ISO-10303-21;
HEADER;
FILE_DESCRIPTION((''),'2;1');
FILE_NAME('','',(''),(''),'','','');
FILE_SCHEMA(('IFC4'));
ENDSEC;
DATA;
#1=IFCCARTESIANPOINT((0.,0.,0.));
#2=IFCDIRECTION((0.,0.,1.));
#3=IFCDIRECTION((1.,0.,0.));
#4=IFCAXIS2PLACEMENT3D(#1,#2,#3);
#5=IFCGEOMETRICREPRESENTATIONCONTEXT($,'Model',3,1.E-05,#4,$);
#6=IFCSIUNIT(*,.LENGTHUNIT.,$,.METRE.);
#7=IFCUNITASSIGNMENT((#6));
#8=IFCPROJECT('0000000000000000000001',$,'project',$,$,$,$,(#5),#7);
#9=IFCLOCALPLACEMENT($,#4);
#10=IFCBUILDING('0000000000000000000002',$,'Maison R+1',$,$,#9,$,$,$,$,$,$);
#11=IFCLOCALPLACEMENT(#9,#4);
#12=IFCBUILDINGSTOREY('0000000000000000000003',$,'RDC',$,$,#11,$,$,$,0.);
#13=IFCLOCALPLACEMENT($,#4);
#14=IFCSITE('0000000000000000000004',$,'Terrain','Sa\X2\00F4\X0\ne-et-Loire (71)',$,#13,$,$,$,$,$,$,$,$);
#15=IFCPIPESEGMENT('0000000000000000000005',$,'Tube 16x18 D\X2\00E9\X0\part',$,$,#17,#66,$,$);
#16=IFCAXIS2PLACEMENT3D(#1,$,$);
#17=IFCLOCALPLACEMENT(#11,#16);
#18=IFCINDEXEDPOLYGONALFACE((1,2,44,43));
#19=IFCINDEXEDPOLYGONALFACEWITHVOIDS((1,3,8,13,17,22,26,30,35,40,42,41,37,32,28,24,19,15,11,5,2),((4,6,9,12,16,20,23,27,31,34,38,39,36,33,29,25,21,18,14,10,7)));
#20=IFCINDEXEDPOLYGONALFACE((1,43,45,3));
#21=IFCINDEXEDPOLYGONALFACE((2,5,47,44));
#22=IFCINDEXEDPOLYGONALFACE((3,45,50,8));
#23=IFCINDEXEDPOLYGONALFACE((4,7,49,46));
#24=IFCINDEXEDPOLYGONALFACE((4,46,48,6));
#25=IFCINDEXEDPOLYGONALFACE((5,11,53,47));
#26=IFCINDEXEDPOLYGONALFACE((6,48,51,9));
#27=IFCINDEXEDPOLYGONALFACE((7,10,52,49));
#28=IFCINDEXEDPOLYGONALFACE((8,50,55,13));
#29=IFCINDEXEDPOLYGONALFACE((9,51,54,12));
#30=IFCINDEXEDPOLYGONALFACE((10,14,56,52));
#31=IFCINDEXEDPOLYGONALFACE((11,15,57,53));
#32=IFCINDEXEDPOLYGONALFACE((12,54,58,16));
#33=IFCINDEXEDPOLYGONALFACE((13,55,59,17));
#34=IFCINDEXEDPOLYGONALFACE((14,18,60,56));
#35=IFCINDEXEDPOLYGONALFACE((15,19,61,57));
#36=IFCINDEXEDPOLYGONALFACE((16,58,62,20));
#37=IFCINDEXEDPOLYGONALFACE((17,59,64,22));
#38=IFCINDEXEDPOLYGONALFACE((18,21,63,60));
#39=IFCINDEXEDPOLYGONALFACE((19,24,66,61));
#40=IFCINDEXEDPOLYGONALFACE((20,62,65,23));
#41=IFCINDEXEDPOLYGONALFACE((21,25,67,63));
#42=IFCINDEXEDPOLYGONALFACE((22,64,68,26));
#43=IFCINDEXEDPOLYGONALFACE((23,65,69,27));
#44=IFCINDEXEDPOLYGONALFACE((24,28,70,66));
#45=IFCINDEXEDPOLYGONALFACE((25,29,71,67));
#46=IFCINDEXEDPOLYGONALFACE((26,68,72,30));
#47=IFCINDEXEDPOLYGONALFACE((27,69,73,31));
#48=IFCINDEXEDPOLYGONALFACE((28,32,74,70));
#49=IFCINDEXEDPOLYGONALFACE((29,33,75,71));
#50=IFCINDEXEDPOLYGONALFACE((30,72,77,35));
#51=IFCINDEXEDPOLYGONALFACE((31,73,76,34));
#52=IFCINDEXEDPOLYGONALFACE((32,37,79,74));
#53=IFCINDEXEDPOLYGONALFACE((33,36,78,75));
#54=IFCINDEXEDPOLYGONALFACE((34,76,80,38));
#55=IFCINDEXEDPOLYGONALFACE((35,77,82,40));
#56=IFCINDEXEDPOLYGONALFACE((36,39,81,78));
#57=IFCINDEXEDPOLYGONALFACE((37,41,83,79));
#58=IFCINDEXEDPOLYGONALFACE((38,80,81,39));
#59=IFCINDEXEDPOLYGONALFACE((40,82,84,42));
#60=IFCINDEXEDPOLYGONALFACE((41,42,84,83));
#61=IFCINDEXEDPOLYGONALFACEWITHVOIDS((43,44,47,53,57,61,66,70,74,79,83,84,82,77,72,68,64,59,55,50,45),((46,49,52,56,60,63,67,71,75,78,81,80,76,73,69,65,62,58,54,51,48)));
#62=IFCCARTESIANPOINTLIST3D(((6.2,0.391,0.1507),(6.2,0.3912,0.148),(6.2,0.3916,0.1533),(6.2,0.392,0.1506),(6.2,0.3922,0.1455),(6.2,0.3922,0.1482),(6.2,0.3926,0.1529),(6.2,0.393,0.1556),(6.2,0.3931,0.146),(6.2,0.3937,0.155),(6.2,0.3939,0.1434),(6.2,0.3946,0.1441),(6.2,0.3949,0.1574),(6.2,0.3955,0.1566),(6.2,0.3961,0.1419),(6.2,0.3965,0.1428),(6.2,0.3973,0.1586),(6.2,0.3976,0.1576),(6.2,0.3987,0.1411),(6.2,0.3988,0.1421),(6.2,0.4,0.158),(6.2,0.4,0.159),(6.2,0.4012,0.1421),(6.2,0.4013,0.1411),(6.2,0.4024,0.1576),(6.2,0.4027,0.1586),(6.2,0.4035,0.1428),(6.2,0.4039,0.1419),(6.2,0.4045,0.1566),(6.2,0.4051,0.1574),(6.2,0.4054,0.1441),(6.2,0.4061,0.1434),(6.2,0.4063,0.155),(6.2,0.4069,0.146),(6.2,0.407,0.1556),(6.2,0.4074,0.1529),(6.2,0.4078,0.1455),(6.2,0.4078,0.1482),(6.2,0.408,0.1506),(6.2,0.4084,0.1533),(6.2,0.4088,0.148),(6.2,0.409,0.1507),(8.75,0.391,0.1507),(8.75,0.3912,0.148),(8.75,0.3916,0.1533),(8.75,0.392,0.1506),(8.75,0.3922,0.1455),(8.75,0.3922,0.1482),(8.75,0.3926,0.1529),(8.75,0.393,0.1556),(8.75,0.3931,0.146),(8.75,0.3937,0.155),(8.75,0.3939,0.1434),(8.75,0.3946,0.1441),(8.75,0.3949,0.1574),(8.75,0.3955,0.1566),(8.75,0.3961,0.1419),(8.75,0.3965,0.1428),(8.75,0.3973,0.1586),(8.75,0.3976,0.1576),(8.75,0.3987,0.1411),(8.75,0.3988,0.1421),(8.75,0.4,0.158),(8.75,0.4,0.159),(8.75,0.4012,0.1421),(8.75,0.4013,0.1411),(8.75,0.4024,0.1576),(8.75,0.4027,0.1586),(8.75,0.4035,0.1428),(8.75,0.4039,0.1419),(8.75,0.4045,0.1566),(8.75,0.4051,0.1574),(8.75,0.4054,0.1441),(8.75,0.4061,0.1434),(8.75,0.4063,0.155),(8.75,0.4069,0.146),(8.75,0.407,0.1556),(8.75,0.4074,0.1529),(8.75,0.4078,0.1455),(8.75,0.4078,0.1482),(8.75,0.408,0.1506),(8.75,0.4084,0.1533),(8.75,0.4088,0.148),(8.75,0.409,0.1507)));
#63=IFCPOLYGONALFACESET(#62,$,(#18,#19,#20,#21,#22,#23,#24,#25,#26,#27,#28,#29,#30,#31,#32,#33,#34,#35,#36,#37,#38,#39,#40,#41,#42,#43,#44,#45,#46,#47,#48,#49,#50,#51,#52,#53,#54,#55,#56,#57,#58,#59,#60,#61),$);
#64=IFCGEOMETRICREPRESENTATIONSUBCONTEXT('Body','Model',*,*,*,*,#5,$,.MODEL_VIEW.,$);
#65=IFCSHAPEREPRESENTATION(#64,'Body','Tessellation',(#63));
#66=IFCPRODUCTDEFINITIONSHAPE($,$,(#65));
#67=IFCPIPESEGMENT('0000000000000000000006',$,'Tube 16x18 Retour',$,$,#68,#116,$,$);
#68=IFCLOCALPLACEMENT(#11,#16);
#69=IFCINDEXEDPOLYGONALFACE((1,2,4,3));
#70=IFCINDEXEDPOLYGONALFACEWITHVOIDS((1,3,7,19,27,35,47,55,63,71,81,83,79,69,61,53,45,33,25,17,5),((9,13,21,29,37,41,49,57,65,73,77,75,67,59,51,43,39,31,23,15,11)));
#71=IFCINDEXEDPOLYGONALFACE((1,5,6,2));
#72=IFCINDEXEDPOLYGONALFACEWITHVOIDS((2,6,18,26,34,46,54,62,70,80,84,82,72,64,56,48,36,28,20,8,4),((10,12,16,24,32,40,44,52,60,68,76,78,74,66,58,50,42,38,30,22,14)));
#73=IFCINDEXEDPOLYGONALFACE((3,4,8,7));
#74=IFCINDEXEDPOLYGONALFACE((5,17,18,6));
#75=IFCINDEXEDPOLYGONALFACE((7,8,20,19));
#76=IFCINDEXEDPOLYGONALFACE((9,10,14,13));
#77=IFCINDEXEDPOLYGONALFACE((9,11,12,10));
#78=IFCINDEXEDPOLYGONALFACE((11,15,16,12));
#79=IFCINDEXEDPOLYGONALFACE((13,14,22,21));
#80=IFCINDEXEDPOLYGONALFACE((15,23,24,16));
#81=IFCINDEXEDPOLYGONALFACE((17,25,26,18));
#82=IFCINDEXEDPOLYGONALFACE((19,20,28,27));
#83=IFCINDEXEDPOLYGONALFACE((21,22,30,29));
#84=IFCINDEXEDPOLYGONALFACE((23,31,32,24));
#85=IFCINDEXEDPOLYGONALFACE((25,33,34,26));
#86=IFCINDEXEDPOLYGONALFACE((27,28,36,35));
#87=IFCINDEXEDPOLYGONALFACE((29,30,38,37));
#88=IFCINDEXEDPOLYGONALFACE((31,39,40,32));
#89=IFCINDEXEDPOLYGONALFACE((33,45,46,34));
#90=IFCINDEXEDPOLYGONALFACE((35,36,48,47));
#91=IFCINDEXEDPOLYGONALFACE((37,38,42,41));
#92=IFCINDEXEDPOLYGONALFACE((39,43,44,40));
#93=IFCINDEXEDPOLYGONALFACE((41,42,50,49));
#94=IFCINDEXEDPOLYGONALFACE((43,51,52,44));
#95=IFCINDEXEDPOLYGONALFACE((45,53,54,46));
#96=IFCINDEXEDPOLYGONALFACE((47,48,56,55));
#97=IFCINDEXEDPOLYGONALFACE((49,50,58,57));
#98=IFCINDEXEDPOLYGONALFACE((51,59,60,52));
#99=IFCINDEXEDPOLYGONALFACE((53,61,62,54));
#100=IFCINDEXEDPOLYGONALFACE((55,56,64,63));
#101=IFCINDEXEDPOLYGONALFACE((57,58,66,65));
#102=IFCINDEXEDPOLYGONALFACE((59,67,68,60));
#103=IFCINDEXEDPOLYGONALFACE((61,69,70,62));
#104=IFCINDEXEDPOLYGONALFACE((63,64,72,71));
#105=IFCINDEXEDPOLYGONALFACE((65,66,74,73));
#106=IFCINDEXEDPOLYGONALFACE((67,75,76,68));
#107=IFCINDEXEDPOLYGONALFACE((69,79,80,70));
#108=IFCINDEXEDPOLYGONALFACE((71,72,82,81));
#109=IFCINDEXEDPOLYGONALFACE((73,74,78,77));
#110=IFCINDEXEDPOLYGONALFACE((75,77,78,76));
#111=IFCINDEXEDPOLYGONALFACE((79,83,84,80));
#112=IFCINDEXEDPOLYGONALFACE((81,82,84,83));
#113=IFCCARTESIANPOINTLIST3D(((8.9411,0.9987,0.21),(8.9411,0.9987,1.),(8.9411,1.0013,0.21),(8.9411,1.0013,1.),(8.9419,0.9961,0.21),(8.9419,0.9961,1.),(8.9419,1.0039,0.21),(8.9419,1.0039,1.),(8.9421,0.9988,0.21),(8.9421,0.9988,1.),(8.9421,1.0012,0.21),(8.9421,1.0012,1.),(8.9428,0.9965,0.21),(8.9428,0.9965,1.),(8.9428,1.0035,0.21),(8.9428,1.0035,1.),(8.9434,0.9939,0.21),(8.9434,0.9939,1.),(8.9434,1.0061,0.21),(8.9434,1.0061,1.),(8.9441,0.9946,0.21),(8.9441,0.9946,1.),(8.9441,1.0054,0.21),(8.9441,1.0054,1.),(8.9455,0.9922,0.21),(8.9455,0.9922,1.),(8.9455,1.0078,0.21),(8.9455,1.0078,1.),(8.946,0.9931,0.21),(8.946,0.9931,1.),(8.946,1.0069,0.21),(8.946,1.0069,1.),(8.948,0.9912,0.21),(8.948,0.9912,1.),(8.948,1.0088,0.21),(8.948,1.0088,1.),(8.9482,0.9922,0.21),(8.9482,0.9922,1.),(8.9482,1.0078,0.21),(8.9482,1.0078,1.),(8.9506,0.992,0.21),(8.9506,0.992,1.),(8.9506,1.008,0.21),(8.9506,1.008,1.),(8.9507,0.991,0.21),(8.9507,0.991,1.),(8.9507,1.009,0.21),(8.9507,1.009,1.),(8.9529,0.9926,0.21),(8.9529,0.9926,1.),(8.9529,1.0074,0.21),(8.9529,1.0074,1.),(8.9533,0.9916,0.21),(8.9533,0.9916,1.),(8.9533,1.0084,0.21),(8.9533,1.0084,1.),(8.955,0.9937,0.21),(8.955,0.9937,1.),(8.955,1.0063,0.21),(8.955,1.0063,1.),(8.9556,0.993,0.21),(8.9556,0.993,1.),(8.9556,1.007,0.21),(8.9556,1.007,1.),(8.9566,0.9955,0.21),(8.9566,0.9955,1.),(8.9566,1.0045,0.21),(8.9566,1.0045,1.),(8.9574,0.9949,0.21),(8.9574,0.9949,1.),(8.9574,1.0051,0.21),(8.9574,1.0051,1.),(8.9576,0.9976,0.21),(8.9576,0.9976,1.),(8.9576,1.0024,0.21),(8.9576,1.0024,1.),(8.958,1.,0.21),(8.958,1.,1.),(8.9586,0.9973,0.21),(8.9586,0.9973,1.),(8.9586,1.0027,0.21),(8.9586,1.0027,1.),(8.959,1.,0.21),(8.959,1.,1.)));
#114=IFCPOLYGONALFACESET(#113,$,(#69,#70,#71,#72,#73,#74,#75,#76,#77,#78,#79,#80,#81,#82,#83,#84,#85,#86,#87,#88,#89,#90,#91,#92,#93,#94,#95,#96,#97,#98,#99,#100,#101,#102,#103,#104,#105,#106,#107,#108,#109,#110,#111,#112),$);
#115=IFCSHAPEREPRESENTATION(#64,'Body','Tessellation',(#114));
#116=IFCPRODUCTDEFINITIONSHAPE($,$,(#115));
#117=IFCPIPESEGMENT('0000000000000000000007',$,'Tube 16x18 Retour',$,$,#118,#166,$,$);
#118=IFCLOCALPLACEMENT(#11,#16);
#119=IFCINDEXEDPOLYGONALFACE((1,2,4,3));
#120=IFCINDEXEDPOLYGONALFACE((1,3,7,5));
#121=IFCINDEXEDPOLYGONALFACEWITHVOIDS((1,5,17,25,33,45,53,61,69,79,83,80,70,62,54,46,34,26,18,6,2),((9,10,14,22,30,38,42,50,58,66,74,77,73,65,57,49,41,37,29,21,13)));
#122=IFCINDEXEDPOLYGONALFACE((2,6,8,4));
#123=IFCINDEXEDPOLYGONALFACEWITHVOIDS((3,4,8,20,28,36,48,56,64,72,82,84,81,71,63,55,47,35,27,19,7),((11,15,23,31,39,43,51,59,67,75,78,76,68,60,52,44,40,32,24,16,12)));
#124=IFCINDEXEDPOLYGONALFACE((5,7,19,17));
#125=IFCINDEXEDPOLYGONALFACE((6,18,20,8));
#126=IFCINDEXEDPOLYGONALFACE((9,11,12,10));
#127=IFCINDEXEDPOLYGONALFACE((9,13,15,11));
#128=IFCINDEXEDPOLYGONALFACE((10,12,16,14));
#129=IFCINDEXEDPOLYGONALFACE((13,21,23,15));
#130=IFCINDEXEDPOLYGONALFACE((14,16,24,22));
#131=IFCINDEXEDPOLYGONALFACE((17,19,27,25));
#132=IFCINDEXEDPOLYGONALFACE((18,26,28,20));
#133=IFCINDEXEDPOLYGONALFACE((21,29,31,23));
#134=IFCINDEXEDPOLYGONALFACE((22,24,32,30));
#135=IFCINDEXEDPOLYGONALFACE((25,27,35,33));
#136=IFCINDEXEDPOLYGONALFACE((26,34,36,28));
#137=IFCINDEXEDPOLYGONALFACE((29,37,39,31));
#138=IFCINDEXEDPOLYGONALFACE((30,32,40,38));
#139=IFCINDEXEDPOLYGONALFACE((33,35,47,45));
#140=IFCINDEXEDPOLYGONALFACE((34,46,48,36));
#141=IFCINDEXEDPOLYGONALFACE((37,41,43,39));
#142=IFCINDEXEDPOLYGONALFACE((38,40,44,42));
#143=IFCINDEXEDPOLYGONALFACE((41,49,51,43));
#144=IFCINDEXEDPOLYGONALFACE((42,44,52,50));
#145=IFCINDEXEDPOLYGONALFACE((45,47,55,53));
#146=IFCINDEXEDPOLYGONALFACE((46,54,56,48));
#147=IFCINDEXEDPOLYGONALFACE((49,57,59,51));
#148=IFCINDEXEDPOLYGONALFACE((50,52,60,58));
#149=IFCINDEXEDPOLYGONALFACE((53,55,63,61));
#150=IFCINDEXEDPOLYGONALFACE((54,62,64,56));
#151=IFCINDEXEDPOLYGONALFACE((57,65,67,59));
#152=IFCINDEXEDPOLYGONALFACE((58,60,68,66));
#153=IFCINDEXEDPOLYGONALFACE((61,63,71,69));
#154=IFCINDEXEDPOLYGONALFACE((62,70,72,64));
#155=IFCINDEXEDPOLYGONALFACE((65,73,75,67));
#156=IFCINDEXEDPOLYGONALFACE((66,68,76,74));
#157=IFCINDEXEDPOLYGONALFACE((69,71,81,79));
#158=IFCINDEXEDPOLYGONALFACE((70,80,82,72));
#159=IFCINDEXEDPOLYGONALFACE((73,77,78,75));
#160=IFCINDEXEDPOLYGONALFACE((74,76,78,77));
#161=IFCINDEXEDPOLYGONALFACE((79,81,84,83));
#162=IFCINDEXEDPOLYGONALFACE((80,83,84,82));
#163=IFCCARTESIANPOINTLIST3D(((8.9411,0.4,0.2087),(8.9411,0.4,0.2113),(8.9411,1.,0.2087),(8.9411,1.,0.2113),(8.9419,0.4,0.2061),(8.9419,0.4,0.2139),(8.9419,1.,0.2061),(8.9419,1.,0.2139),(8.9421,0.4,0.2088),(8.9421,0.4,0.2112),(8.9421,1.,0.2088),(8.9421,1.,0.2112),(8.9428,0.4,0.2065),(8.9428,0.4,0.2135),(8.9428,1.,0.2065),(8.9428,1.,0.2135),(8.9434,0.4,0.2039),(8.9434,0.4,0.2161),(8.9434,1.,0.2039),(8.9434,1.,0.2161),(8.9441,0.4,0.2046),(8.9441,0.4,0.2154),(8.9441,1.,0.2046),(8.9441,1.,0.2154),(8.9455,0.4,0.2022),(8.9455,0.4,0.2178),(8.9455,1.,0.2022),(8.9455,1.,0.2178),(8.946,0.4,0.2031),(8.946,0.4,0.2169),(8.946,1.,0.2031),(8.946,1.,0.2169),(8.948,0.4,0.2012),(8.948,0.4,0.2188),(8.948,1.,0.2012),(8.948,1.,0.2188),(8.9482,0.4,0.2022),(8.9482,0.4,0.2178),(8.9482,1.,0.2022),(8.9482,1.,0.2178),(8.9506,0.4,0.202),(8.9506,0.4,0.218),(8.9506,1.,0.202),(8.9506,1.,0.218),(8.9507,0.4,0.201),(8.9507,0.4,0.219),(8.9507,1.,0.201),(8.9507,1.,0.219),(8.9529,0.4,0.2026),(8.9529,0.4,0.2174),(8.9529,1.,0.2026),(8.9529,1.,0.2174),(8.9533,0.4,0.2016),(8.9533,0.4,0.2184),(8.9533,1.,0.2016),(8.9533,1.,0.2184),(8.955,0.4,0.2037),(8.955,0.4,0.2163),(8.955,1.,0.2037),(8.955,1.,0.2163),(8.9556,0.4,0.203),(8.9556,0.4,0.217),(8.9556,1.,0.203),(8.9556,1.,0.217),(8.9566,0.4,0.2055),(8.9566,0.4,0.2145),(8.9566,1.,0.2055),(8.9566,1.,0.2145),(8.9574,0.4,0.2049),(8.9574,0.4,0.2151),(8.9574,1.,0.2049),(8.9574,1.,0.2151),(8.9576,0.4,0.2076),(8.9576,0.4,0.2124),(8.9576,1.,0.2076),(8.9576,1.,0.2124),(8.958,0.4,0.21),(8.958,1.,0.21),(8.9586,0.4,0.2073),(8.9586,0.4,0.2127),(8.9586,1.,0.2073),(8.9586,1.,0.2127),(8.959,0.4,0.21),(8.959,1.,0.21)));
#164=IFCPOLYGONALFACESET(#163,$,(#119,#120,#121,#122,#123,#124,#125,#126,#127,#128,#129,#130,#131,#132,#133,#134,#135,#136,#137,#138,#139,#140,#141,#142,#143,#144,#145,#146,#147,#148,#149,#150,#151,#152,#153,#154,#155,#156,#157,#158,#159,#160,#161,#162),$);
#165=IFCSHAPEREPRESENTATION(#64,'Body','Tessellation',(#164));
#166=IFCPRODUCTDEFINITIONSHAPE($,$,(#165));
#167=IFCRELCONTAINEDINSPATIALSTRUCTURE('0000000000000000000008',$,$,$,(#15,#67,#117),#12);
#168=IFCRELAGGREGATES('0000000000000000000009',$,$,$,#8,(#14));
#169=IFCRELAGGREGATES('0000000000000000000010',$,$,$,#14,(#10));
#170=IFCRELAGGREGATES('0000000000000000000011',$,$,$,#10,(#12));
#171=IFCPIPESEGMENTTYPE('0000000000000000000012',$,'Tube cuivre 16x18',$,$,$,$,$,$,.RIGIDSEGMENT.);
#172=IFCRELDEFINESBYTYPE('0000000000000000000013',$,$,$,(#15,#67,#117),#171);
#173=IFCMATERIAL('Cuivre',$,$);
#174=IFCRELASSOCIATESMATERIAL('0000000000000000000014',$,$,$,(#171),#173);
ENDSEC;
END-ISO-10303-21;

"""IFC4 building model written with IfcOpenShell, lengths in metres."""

from ifc_helpers import new_model, si_unit, frame, origin_with_axes, place, context, subcontext, project, spatial, hollow_circle, extrude, material, type_object, element, save


model = new_model("IFC4")

# Units and contexts
model_context = context("Model", 3, precision=1e-05, world=origin_with_axes())
body_context = subcontext(model_context, "Body", "Model", "MODEL_VIEW")
ifc_project = project(units=[si_unit("LENGTHUNIT", "METRE")], contexts=[model_context])

# Site, building, storey
site_placement = place(None, origin_with_axes())
site = spatial("IfcSite", under=ifc_project, at=site_placement, Name="Terrain", Description="Saône-et-Loire (71)")
building_placement = place(None, origin_with_axes())
building = spatial("IfcBuilding", under=site, at=building_placement, Name="Maison R+1")
storey_placement = place(building_placement, origin_with_axes())
storey = spatial("IfcBuildingStorey", under=building, at=storey_placement, Name="RDC", Elevation=0.0)

# Pipe segments
ifc_material_1 = material(Name="Cuivre")
pipe_segment_type_1 = type_object("IfcPipeSegmentType", Name="Tube cuivre 16x18", PredefinedType="RIGIDSEGMENT", material=ifc_material_1)
pipe_segment_1_placement = place(storey_placement, frame((8.75, 0.4, 0.15), z_axis=(-1.0, 0.0, 0.0), x_axis=(0.0, 0.0, 1.0)))
element("IfcPipeSegment", 1, at=pipe_segment_1_placement, inside=storey, type_object=pipe_segment_type_1, Name="Tube 16x18 Départ", context=body_context, shape_type="SweptSolid", body=[
    extrude(hollow_circle(Radius=0.009, WallThickness=0.001), origin_with_axes(), (0.0, 0.0, 1.0), 2.55),
])
pipe_segment_2_placement = place(storey_placement, frame((8.95, 1.0, 1.0), z_axis=(0.0, 0.0, -1.0), x_axis=(1.0, 0.0, 0.0)))
element("IfcPipeSegment", 2, at=pipe_segment_2_placement, inside=storey, type_object=pipe_segment_type_1, Name="Tube 16x18 Retour", context=body_context, shape_type="SweptSolid", body=[
    extrude(hollow_circle(Radius=0.009, WallThickness=0.001), origin_with_axes(), (0.0, 0.0, 1.0), 0.79),
])
pipe_segment_3_placement = place(storey_placement, frame((8.95, 1.0, 0.21), z_axis=(0.0, -1.0, 0.0), x_axis=(1.0, 0.0, 0.0)))
element("IfcPipeSegment", 3, at=pipe_segment_3_placement, inside=storey, type_object=pipe_segment_type_1, Name="Tube 16x18 Retour", context=body_context, shape_type="SweptSolid", body=[
    extrude(hollow_circle(Radius=0.009, WallThickness=0.001), origin_with_axes(), (0.0, 0.0, 1.0), 0.6),
])

save(model, "model.ifc")
